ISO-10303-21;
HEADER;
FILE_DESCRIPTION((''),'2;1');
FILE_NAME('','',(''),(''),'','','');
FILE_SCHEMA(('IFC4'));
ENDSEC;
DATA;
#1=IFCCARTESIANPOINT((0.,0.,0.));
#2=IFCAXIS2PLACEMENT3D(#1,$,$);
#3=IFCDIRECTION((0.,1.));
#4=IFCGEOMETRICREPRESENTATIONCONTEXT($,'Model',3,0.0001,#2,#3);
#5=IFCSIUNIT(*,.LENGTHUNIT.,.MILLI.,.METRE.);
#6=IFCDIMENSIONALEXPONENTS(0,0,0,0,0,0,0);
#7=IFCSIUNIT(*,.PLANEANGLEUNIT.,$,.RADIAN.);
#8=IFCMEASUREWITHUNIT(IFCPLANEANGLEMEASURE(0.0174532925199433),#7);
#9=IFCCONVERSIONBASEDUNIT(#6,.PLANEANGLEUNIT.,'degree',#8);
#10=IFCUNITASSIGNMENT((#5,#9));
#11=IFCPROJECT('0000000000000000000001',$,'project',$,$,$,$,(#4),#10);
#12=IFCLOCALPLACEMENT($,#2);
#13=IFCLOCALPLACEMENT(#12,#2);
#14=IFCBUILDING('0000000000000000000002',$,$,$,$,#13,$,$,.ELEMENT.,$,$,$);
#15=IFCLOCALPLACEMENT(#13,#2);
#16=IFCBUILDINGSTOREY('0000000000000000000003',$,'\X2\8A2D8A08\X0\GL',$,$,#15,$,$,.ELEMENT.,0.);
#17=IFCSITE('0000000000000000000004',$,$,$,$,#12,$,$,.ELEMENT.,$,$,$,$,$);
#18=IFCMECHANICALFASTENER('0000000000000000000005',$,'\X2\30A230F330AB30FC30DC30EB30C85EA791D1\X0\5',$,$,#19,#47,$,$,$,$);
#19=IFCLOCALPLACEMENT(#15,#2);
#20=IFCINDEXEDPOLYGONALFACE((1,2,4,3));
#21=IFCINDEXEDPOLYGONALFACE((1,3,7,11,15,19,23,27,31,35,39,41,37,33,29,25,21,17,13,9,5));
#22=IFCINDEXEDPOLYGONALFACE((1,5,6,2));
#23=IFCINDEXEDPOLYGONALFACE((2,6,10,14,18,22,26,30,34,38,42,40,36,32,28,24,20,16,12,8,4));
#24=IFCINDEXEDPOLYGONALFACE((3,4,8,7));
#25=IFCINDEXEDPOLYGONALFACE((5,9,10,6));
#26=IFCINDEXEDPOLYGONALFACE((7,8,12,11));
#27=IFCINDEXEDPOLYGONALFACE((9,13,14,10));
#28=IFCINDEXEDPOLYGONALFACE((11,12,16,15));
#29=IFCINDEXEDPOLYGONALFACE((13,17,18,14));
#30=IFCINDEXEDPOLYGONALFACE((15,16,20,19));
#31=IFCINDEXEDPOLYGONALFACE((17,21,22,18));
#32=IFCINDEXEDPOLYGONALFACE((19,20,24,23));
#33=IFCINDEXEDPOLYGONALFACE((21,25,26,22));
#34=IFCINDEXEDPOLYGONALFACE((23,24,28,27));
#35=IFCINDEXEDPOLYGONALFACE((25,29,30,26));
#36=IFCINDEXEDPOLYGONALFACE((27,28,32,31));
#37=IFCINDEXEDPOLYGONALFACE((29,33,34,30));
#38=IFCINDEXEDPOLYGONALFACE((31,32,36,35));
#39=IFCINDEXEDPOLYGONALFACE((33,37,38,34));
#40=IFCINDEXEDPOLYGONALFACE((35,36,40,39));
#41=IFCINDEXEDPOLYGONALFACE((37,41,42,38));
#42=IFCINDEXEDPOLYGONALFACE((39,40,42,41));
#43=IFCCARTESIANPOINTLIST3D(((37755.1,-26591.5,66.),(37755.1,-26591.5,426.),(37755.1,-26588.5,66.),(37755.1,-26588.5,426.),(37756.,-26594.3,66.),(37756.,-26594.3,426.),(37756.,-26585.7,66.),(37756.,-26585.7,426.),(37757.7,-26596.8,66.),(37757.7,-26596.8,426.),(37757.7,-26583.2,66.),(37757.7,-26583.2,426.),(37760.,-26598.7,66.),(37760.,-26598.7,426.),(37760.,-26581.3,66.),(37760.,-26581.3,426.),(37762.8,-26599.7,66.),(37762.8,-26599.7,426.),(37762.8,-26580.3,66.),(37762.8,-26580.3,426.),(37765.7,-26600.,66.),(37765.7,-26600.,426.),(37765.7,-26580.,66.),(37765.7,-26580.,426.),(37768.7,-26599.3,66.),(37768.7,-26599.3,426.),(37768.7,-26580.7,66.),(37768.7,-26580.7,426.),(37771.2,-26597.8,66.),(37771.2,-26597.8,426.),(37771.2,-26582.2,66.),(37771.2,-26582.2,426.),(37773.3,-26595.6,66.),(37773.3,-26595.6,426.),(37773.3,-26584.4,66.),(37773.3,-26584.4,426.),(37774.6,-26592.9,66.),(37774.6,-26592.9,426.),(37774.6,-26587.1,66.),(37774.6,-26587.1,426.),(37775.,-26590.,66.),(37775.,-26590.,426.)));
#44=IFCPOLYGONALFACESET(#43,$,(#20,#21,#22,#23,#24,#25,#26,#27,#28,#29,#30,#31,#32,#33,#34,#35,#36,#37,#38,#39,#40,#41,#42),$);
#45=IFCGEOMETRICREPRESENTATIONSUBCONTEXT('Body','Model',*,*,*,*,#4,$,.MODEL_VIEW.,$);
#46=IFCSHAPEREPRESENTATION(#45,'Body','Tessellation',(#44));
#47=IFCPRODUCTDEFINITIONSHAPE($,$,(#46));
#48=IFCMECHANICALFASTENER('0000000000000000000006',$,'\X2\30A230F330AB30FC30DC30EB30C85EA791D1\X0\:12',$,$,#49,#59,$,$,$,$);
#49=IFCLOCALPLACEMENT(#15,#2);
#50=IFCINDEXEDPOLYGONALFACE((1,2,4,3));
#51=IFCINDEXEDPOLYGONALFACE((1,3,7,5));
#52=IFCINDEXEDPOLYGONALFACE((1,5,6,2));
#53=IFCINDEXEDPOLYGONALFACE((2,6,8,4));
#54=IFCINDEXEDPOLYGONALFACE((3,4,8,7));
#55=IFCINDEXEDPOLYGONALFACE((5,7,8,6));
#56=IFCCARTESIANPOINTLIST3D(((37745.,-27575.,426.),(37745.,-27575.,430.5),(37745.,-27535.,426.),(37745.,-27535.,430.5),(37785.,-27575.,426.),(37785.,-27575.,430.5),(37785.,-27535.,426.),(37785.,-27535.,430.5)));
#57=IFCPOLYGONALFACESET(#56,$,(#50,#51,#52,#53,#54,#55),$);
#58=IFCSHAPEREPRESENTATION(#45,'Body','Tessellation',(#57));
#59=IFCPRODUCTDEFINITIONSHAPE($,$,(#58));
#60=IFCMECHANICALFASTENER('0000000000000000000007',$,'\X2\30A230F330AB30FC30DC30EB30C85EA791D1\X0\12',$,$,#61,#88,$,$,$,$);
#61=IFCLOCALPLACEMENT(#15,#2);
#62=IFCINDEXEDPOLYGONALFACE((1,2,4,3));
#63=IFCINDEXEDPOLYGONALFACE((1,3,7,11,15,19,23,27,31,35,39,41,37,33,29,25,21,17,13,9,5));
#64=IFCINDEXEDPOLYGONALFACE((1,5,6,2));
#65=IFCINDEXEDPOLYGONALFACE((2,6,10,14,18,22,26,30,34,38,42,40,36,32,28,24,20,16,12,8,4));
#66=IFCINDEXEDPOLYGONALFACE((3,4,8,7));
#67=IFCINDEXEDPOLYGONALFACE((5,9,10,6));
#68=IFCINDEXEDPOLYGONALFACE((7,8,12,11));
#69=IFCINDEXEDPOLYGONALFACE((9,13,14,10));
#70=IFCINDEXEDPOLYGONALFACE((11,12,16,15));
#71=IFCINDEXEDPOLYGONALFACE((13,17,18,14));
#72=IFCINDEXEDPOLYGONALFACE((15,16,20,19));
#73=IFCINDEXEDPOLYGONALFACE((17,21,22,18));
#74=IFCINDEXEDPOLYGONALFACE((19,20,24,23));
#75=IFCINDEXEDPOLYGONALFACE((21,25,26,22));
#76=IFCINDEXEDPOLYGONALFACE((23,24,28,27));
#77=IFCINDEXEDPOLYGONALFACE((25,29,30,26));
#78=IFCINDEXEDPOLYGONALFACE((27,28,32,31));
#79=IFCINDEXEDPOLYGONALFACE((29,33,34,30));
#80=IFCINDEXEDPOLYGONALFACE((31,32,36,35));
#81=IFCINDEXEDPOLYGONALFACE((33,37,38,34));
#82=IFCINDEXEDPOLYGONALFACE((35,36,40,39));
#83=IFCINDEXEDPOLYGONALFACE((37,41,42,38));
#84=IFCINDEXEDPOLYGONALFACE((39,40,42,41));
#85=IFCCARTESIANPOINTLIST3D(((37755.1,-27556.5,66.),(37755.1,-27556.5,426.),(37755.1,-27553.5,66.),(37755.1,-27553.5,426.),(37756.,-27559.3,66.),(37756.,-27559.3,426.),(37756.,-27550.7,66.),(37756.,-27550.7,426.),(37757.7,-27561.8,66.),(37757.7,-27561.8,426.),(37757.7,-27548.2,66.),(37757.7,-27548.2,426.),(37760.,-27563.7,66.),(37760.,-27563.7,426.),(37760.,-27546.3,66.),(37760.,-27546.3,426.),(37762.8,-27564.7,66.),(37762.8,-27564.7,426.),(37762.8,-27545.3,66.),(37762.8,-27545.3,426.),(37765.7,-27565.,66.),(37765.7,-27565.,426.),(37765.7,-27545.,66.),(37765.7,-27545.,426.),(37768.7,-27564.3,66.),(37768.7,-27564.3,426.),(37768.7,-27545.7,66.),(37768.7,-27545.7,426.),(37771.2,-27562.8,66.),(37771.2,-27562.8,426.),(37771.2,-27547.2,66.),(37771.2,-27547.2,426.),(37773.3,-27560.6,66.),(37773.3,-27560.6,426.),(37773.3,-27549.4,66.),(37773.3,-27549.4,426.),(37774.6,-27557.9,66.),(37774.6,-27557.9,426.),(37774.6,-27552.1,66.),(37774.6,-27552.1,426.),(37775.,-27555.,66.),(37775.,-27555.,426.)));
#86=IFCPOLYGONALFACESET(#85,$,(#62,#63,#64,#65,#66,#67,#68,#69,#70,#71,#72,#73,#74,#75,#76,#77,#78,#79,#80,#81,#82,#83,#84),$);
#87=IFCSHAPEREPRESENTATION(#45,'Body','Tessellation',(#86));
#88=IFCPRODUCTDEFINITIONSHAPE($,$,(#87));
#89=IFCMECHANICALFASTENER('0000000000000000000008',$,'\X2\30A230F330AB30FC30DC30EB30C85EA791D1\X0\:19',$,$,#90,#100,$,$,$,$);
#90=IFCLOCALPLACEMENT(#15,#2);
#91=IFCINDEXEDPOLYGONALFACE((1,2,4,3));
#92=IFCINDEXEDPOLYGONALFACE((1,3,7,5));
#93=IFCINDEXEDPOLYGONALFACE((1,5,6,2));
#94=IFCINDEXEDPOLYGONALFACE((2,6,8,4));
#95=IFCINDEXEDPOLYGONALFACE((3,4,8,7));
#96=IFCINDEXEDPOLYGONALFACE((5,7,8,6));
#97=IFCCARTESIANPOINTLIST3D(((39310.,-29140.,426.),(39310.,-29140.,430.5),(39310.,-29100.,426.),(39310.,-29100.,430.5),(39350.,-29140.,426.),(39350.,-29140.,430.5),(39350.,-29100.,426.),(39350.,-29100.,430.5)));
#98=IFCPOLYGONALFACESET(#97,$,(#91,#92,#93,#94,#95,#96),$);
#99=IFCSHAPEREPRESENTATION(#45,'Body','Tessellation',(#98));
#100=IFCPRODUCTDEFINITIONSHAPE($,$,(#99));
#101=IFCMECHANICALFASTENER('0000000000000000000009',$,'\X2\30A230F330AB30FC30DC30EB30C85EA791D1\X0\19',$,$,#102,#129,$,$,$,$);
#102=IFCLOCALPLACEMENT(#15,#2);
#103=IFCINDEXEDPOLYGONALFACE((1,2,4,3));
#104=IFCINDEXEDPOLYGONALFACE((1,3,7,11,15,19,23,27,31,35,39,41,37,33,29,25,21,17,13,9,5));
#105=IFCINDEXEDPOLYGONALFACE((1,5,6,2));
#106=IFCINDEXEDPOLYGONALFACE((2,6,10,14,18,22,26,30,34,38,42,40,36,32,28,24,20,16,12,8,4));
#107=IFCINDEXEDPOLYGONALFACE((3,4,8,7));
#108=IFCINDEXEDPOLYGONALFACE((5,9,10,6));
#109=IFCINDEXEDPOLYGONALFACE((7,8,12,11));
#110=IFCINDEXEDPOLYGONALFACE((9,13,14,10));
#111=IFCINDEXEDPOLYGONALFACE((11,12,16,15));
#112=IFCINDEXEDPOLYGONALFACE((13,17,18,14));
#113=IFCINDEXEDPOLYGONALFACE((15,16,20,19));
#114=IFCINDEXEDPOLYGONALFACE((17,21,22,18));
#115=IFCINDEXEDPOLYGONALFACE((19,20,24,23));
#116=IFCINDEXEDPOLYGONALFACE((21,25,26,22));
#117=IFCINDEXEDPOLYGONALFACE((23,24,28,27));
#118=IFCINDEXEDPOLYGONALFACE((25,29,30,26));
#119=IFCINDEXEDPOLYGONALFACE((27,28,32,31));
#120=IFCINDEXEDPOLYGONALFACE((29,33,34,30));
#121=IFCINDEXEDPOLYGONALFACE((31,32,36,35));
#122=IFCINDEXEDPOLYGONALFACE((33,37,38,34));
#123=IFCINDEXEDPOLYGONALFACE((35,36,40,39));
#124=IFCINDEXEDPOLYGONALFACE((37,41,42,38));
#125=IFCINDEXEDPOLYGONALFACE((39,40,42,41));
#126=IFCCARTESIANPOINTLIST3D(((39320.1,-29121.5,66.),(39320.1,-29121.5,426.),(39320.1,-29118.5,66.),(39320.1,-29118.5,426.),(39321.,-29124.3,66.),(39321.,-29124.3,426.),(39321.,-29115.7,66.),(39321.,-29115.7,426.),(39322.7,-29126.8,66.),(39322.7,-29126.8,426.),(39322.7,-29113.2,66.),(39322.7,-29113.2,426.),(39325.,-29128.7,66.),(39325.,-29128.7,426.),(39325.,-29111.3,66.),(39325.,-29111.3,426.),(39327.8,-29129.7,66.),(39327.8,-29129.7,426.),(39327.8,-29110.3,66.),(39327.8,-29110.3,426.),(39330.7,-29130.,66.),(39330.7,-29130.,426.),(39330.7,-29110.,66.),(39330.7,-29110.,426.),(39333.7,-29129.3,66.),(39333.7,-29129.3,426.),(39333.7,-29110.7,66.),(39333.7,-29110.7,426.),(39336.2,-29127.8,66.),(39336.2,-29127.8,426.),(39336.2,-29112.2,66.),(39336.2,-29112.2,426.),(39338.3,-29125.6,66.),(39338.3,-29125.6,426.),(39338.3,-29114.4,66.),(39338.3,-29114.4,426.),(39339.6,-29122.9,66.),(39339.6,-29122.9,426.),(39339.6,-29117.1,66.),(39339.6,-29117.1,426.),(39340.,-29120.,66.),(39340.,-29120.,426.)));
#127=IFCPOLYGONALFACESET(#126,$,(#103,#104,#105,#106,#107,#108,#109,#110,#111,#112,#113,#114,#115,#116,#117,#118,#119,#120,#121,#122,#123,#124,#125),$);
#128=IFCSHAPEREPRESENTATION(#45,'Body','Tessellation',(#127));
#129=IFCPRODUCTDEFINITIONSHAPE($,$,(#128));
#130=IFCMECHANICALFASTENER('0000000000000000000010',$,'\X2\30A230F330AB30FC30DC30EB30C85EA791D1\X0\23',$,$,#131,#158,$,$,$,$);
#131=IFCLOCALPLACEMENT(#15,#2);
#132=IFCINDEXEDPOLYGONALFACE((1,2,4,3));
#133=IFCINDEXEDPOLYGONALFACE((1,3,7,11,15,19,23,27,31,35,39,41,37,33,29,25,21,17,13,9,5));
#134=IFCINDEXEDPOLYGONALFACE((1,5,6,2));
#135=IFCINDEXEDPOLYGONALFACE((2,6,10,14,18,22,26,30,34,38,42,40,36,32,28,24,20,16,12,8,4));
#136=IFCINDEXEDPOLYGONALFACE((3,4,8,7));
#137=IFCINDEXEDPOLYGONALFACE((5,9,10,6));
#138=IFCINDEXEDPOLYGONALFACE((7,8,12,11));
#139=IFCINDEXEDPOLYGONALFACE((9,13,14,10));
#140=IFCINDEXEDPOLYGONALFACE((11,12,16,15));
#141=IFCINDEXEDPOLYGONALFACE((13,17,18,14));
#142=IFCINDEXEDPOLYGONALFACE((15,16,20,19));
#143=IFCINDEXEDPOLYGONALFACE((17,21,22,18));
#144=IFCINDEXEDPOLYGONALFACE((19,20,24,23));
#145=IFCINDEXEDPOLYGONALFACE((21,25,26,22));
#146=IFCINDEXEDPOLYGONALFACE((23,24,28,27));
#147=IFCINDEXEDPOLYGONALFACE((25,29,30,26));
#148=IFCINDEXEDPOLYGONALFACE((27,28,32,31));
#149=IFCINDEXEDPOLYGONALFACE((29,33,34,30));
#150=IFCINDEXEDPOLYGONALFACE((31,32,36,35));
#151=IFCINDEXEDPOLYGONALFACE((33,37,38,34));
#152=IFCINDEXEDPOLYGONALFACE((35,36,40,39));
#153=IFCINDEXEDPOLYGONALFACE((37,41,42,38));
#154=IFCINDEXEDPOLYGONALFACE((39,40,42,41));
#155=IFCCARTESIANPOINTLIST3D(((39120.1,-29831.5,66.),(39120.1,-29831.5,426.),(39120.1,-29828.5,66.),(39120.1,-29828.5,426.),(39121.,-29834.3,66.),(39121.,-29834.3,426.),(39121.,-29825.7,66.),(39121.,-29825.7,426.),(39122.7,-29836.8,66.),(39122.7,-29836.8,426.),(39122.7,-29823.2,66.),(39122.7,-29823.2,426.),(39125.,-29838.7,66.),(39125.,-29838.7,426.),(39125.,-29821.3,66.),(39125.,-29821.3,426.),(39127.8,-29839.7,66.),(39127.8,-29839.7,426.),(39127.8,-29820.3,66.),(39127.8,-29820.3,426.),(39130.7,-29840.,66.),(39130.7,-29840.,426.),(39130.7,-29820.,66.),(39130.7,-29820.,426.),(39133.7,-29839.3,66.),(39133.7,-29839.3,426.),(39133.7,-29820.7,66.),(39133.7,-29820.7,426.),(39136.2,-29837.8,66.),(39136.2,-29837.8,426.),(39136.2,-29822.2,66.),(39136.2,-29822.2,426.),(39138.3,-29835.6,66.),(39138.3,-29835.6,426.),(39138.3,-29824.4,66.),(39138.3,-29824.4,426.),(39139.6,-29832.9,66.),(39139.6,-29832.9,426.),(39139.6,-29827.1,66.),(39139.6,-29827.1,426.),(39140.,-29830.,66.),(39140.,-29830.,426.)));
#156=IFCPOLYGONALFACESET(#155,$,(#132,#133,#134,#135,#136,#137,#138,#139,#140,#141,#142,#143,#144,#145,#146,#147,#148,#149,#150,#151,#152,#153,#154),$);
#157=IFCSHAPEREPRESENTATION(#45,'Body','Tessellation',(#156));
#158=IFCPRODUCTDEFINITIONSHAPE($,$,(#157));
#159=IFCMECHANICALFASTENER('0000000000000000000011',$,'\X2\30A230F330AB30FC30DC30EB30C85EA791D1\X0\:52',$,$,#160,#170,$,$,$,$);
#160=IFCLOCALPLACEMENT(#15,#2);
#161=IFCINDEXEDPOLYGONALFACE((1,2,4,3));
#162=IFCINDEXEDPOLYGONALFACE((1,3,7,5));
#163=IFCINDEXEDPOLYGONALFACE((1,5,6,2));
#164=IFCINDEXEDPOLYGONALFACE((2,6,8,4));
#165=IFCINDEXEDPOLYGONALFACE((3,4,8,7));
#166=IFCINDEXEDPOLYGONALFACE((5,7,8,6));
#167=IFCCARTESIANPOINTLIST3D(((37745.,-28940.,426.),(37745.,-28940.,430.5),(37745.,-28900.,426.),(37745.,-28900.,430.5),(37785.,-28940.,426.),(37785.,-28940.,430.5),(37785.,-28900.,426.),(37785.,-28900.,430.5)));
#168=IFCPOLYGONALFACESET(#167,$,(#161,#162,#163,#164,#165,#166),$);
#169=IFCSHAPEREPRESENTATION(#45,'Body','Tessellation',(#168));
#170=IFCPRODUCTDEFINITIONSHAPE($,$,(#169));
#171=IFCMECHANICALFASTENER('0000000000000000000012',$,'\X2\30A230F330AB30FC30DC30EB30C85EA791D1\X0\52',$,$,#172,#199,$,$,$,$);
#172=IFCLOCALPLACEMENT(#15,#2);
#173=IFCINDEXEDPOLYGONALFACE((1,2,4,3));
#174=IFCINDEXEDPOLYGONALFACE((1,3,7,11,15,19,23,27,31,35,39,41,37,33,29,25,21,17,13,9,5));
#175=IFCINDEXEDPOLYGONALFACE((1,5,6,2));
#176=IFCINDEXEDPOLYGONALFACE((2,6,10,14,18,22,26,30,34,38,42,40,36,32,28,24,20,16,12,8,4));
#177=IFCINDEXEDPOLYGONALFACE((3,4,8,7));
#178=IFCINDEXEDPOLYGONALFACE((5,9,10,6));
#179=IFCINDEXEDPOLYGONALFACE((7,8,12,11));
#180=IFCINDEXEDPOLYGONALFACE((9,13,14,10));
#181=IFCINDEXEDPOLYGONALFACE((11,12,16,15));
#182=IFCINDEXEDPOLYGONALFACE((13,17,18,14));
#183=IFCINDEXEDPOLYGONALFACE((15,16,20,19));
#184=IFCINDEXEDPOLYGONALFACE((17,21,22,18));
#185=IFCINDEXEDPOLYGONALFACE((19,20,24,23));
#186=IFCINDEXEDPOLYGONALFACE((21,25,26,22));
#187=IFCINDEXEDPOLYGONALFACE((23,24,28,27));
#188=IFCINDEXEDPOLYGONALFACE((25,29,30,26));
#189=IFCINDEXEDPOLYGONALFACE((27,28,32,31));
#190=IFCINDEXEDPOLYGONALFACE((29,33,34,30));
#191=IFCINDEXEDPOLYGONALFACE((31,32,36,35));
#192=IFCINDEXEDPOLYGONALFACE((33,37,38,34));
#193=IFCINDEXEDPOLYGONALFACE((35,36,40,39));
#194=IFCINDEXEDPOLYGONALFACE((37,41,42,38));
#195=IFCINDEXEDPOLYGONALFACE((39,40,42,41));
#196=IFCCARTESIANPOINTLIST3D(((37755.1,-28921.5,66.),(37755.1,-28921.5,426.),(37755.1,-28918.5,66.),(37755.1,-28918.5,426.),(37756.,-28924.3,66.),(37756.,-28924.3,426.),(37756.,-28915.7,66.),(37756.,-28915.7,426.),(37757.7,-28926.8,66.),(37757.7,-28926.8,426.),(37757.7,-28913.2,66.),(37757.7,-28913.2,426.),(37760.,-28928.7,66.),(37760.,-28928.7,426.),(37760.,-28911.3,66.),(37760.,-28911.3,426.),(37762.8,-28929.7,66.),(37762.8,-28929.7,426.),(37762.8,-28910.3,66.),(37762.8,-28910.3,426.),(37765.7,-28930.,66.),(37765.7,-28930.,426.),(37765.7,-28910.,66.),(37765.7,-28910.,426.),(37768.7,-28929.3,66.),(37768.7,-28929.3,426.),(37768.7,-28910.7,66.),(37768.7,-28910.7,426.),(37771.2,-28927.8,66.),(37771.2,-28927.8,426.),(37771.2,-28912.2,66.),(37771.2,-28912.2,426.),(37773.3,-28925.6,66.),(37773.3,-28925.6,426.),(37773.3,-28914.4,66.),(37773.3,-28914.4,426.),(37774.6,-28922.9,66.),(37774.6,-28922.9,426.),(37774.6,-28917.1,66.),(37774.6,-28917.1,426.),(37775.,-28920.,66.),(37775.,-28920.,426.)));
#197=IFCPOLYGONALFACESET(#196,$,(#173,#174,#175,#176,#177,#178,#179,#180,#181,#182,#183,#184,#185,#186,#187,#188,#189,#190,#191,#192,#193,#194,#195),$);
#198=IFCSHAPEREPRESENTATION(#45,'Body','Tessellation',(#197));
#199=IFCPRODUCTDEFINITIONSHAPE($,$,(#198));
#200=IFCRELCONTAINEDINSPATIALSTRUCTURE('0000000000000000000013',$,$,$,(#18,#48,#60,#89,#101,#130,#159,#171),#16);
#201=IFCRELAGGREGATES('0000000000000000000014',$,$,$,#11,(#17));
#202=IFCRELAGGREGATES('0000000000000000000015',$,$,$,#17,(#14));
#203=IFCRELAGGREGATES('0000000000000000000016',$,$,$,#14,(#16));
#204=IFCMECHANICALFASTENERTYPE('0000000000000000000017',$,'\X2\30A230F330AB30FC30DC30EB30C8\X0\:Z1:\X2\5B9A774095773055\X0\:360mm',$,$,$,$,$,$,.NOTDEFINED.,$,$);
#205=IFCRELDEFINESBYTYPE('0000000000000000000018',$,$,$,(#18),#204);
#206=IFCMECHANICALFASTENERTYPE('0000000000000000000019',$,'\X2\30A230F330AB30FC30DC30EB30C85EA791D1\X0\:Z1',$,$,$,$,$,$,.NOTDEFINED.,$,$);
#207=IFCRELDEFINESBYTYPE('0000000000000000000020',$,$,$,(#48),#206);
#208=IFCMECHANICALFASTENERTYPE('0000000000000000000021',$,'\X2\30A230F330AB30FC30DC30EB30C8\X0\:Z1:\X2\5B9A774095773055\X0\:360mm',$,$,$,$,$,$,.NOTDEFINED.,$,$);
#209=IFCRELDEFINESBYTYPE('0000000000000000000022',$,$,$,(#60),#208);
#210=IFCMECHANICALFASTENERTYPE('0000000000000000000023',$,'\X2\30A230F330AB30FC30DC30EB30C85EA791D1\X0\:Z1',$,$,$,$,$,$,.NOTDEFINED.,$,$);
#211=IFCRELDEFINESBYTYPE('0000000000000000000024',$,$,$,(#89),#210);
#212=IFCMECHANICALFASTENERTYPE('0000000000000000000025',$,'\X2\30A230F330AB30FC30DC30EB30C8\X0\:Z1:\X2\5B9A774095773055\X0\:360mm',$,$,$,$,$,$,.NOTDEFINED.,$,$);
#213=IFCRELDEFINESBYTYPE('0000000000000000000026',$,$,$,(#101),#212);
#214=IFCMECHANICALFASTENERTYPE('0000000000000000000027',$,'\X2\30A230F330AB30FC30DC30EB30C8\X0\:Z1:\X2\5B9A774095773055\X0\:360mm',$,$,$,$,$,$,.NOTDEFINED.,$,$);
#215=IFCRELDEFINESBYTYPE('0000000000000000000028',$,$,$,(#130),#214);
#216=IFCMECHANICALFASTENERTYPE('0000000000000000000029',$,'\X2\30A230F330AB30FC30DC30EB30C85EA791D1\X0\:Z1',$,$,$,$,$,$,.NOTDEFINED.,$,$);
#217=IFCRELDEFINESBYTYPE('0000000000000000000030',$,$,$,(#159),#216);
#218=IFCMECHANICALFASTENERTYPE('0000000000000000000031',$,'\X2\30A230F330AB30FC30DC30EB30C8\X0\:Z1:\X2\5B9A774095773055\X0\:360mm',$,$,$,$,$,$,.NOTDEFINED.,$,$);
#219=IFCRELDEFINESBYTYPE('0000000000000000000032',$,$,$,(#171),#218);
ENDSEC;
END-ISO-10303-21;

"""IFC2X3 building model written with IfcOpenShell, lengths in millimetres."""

from ifc_helpers import new_model, entity, si_unit, converted_unit, direction, frame, origin, origin_with_axes, origin_2d, place, context, subcontext, project, spatial, rectangle, circle, extrude, type_object, element, save


model = new_model("IFC2X3")

# Units and contexts
model_context = context("Model", 3, precision=0.0001, world=origin(), true_north=direction((0.0, 1.0)))
body_context = subcontext(model_context, "Body", "Model", "MODEL_VIEW")
ifc_project = project(units=[si_unit("LENGTHUNIT", "METRE", prefix="MILLI"), converted_unit("PLANEANGLEUNIT", "degree", entity("IfcPlaneAngleMeasure", 0.0174532925199433), si_unit("PLANEANGLEUNIT", "RADIAN"), dimensions=[0, 0, 0, 0, 0, 0, 0])], contexts=[model_context])

# Site, building, storey
site_placement = place(None, origin())
site = spatial("IfcSite", under=ifc_project, at=site_placement, CompositionType="ELEMENT")
building_placement = place(site_placement, origin())
building = spatial("IfcBuilding", under=site, at=building_placement, CompositionType="ELEMENT")
storey_placement = place(building_placement, origin())
storey = spatial("IfcBuildingStorey", under=building, at=storey_placement, Name="設計GL", CompositionType="ELEMENT", Elevation=0.0)

# Mechanical fasteners
mechanical_fastener_type_1 = type_object("IfcMechanicalFastenerType", Name="アンカーボルト:Z1:定着長さ:360mm")
mechanical_fastener_1_placement = place(storey_placement, frame((37765.0, -26590.0, 66.0)))
element("IfcMechanicalFastener", 1, at=mechanical_fastener_1_placement, inside=storey, type_object=mechanical_fastener_type_1, Name="アンカーボルト座金5", context=body_context, shape_type="SweptSolid", body=[
    extrude(circle(Radius=10.0, at=origin_2d()), origin_with_axes(), (0.0, 0.0, 1.0), 360.0),
])
mechanical_fastener_type_2 = type_object("IfcMechanicalFastenerType", Name="アンカーボルト座金:Z1")
mechanical_fastener_2_placement = place(storey_placement, frame((37765.0, -27555.0, 426.0)))
element("IfcMechanicalFastener", 2, at=mechanical_fastener_2_placement, inside=storey, type_object=mechanical_fastener_type_2, Name="アンカーボルト座金:12", context=body_context, shape_type="SweptSolid", body=[
    extrude(rectangle(XDim=40.0, YDim=40.0, at=origin_2d()), origin_with_axes(), (0.0, 0.0, 1.0), 4.5),
])
mechanical_fastener_type_3 = type_object("IfcMechanicalFastenerType", Name="アンカーボルト:Z1:定着長さ:360mm")
mechanical_fastener_3_placement = place(storey_placement, frame((37765.0, -27555.0, 66.0)))
element("IfcMechanicalFastener", 3, at=mechanical_fastener_3_placement, inside=storey, type_object=mechanical_fastener_type_3, Name="アンカーボルト座金12", context=body_context, shape_type="SweptSolid", body=[
    extrude(circle(Radius=10.0, at=origin_2d()), origin_with_axes(), (0.0, 0.0, 1.0), 360.0),
])
mechanical_fastener_type_4 = type_object("IfcMechanicalFastenerType", Name="アンカーボルト座金:Z1")
mechanical_fastener_4_placement = place(storey_placement, frame((39330.0, -29120.0, 426.0)))
element("IfcMechanicalFastener", 4, at=mechanical_fastener_4_placement, inside=storey, type_object=mechanical_fastener_type_4, Name="アンカーボルト座金:19", context=body_context, shape_type="SweptSolid", body=[
    extrude(rectangle(XDim=40.0, YDim=40.0, at=origin_2d()), origin_with_axes(), (0.0, 0.0, 1.0), 4.5),
])
mechanical_fastener_type_5 = type_object("IfcMechanicalFastenerType", Name="アンカーボルト:Z1:定着長さ:360mm")
mechanical_fastener_5_placement = place(storey_placement, frame((39330.0, -29120.0, 66.0)))
element("IfcMechanicalFastener", 5, at=mechanical_fastener_5_placement, inside=storey, type_object=mechanical_fastener_type_5, Name="アンカーボルト座金19", context=body_context, shape_type="SweptSolid", body=[
    extrude(circle(Radius=10.0, at=origin_2d()), origin_with_axes(), (0.0, 0.0, 1.0), 360.0),
])
mechanical_fastener_type_6 = type_object("IfcMechanicalFastenerType", Name="アンカーボルト:Z1:定着長さ:360mm")
mechanical_fastener_6_placement = place(storey_placement, frame((39130.0, -29830.0, 66.0)))
element("IfcMechanicalFastener", 6, at=mechanical_fastener_6_placement, inside=storey, type_object=mechanical_fastener_type_6, Name="アンカーボルト座金23", context=body_context, shape_type="SweptSolid", body=[
    extrude(circle(Radius=10.0, at=origin_2d()), origin_with_axes(), (0.0, 0.0, 1.0), 360.0),
])
mechanical_fastener_type_7 = type_object("IfcMechanicalFastenerType", Name="アンカーボルト座金:Z1")
mechanical_fastener_7_placement = place(storey_placement, frame((37765.0, -28920.0, 426.0)))
element("IfcMechanicalFastener", 7, at=mechanical_fastener_7_placement, inside=storey, type_object=mechanical_fastener_type_7, Name="アンカーボルト座金:52", context=body_context, shape_type="SweptSolid", body=[
    extrude(rectangle(XDim=40.0, YDim=40.0, at=origin_2d()), origin_with_axes(), (0.0, 0.0, 1.0), 4.5),
])
mechanical_fastener_type_8 = type_object("IfcMechanicalFastenerType", Name="アンカーボルト:Z1:定着長さ:360mm")
mechanical_fastener_8_placement = place(storey_placement, frame((37765.0, -28920.0, 66.0)))
element("IfcMechanicalFastener", 8, at=mechanical_fastener_8_placement, inside=storey, type_object=mechanical_fastener_type_8, Name="アンカーボルト座金52", context=body_context, shape_type="SweptSolid", body=[
    extrude(circle(Radius=10.0, at=origin_2d()), origin_with_axes(), (0.0, 0.0, 1.0), 360.0),
])

save(model, "model.ifc")
